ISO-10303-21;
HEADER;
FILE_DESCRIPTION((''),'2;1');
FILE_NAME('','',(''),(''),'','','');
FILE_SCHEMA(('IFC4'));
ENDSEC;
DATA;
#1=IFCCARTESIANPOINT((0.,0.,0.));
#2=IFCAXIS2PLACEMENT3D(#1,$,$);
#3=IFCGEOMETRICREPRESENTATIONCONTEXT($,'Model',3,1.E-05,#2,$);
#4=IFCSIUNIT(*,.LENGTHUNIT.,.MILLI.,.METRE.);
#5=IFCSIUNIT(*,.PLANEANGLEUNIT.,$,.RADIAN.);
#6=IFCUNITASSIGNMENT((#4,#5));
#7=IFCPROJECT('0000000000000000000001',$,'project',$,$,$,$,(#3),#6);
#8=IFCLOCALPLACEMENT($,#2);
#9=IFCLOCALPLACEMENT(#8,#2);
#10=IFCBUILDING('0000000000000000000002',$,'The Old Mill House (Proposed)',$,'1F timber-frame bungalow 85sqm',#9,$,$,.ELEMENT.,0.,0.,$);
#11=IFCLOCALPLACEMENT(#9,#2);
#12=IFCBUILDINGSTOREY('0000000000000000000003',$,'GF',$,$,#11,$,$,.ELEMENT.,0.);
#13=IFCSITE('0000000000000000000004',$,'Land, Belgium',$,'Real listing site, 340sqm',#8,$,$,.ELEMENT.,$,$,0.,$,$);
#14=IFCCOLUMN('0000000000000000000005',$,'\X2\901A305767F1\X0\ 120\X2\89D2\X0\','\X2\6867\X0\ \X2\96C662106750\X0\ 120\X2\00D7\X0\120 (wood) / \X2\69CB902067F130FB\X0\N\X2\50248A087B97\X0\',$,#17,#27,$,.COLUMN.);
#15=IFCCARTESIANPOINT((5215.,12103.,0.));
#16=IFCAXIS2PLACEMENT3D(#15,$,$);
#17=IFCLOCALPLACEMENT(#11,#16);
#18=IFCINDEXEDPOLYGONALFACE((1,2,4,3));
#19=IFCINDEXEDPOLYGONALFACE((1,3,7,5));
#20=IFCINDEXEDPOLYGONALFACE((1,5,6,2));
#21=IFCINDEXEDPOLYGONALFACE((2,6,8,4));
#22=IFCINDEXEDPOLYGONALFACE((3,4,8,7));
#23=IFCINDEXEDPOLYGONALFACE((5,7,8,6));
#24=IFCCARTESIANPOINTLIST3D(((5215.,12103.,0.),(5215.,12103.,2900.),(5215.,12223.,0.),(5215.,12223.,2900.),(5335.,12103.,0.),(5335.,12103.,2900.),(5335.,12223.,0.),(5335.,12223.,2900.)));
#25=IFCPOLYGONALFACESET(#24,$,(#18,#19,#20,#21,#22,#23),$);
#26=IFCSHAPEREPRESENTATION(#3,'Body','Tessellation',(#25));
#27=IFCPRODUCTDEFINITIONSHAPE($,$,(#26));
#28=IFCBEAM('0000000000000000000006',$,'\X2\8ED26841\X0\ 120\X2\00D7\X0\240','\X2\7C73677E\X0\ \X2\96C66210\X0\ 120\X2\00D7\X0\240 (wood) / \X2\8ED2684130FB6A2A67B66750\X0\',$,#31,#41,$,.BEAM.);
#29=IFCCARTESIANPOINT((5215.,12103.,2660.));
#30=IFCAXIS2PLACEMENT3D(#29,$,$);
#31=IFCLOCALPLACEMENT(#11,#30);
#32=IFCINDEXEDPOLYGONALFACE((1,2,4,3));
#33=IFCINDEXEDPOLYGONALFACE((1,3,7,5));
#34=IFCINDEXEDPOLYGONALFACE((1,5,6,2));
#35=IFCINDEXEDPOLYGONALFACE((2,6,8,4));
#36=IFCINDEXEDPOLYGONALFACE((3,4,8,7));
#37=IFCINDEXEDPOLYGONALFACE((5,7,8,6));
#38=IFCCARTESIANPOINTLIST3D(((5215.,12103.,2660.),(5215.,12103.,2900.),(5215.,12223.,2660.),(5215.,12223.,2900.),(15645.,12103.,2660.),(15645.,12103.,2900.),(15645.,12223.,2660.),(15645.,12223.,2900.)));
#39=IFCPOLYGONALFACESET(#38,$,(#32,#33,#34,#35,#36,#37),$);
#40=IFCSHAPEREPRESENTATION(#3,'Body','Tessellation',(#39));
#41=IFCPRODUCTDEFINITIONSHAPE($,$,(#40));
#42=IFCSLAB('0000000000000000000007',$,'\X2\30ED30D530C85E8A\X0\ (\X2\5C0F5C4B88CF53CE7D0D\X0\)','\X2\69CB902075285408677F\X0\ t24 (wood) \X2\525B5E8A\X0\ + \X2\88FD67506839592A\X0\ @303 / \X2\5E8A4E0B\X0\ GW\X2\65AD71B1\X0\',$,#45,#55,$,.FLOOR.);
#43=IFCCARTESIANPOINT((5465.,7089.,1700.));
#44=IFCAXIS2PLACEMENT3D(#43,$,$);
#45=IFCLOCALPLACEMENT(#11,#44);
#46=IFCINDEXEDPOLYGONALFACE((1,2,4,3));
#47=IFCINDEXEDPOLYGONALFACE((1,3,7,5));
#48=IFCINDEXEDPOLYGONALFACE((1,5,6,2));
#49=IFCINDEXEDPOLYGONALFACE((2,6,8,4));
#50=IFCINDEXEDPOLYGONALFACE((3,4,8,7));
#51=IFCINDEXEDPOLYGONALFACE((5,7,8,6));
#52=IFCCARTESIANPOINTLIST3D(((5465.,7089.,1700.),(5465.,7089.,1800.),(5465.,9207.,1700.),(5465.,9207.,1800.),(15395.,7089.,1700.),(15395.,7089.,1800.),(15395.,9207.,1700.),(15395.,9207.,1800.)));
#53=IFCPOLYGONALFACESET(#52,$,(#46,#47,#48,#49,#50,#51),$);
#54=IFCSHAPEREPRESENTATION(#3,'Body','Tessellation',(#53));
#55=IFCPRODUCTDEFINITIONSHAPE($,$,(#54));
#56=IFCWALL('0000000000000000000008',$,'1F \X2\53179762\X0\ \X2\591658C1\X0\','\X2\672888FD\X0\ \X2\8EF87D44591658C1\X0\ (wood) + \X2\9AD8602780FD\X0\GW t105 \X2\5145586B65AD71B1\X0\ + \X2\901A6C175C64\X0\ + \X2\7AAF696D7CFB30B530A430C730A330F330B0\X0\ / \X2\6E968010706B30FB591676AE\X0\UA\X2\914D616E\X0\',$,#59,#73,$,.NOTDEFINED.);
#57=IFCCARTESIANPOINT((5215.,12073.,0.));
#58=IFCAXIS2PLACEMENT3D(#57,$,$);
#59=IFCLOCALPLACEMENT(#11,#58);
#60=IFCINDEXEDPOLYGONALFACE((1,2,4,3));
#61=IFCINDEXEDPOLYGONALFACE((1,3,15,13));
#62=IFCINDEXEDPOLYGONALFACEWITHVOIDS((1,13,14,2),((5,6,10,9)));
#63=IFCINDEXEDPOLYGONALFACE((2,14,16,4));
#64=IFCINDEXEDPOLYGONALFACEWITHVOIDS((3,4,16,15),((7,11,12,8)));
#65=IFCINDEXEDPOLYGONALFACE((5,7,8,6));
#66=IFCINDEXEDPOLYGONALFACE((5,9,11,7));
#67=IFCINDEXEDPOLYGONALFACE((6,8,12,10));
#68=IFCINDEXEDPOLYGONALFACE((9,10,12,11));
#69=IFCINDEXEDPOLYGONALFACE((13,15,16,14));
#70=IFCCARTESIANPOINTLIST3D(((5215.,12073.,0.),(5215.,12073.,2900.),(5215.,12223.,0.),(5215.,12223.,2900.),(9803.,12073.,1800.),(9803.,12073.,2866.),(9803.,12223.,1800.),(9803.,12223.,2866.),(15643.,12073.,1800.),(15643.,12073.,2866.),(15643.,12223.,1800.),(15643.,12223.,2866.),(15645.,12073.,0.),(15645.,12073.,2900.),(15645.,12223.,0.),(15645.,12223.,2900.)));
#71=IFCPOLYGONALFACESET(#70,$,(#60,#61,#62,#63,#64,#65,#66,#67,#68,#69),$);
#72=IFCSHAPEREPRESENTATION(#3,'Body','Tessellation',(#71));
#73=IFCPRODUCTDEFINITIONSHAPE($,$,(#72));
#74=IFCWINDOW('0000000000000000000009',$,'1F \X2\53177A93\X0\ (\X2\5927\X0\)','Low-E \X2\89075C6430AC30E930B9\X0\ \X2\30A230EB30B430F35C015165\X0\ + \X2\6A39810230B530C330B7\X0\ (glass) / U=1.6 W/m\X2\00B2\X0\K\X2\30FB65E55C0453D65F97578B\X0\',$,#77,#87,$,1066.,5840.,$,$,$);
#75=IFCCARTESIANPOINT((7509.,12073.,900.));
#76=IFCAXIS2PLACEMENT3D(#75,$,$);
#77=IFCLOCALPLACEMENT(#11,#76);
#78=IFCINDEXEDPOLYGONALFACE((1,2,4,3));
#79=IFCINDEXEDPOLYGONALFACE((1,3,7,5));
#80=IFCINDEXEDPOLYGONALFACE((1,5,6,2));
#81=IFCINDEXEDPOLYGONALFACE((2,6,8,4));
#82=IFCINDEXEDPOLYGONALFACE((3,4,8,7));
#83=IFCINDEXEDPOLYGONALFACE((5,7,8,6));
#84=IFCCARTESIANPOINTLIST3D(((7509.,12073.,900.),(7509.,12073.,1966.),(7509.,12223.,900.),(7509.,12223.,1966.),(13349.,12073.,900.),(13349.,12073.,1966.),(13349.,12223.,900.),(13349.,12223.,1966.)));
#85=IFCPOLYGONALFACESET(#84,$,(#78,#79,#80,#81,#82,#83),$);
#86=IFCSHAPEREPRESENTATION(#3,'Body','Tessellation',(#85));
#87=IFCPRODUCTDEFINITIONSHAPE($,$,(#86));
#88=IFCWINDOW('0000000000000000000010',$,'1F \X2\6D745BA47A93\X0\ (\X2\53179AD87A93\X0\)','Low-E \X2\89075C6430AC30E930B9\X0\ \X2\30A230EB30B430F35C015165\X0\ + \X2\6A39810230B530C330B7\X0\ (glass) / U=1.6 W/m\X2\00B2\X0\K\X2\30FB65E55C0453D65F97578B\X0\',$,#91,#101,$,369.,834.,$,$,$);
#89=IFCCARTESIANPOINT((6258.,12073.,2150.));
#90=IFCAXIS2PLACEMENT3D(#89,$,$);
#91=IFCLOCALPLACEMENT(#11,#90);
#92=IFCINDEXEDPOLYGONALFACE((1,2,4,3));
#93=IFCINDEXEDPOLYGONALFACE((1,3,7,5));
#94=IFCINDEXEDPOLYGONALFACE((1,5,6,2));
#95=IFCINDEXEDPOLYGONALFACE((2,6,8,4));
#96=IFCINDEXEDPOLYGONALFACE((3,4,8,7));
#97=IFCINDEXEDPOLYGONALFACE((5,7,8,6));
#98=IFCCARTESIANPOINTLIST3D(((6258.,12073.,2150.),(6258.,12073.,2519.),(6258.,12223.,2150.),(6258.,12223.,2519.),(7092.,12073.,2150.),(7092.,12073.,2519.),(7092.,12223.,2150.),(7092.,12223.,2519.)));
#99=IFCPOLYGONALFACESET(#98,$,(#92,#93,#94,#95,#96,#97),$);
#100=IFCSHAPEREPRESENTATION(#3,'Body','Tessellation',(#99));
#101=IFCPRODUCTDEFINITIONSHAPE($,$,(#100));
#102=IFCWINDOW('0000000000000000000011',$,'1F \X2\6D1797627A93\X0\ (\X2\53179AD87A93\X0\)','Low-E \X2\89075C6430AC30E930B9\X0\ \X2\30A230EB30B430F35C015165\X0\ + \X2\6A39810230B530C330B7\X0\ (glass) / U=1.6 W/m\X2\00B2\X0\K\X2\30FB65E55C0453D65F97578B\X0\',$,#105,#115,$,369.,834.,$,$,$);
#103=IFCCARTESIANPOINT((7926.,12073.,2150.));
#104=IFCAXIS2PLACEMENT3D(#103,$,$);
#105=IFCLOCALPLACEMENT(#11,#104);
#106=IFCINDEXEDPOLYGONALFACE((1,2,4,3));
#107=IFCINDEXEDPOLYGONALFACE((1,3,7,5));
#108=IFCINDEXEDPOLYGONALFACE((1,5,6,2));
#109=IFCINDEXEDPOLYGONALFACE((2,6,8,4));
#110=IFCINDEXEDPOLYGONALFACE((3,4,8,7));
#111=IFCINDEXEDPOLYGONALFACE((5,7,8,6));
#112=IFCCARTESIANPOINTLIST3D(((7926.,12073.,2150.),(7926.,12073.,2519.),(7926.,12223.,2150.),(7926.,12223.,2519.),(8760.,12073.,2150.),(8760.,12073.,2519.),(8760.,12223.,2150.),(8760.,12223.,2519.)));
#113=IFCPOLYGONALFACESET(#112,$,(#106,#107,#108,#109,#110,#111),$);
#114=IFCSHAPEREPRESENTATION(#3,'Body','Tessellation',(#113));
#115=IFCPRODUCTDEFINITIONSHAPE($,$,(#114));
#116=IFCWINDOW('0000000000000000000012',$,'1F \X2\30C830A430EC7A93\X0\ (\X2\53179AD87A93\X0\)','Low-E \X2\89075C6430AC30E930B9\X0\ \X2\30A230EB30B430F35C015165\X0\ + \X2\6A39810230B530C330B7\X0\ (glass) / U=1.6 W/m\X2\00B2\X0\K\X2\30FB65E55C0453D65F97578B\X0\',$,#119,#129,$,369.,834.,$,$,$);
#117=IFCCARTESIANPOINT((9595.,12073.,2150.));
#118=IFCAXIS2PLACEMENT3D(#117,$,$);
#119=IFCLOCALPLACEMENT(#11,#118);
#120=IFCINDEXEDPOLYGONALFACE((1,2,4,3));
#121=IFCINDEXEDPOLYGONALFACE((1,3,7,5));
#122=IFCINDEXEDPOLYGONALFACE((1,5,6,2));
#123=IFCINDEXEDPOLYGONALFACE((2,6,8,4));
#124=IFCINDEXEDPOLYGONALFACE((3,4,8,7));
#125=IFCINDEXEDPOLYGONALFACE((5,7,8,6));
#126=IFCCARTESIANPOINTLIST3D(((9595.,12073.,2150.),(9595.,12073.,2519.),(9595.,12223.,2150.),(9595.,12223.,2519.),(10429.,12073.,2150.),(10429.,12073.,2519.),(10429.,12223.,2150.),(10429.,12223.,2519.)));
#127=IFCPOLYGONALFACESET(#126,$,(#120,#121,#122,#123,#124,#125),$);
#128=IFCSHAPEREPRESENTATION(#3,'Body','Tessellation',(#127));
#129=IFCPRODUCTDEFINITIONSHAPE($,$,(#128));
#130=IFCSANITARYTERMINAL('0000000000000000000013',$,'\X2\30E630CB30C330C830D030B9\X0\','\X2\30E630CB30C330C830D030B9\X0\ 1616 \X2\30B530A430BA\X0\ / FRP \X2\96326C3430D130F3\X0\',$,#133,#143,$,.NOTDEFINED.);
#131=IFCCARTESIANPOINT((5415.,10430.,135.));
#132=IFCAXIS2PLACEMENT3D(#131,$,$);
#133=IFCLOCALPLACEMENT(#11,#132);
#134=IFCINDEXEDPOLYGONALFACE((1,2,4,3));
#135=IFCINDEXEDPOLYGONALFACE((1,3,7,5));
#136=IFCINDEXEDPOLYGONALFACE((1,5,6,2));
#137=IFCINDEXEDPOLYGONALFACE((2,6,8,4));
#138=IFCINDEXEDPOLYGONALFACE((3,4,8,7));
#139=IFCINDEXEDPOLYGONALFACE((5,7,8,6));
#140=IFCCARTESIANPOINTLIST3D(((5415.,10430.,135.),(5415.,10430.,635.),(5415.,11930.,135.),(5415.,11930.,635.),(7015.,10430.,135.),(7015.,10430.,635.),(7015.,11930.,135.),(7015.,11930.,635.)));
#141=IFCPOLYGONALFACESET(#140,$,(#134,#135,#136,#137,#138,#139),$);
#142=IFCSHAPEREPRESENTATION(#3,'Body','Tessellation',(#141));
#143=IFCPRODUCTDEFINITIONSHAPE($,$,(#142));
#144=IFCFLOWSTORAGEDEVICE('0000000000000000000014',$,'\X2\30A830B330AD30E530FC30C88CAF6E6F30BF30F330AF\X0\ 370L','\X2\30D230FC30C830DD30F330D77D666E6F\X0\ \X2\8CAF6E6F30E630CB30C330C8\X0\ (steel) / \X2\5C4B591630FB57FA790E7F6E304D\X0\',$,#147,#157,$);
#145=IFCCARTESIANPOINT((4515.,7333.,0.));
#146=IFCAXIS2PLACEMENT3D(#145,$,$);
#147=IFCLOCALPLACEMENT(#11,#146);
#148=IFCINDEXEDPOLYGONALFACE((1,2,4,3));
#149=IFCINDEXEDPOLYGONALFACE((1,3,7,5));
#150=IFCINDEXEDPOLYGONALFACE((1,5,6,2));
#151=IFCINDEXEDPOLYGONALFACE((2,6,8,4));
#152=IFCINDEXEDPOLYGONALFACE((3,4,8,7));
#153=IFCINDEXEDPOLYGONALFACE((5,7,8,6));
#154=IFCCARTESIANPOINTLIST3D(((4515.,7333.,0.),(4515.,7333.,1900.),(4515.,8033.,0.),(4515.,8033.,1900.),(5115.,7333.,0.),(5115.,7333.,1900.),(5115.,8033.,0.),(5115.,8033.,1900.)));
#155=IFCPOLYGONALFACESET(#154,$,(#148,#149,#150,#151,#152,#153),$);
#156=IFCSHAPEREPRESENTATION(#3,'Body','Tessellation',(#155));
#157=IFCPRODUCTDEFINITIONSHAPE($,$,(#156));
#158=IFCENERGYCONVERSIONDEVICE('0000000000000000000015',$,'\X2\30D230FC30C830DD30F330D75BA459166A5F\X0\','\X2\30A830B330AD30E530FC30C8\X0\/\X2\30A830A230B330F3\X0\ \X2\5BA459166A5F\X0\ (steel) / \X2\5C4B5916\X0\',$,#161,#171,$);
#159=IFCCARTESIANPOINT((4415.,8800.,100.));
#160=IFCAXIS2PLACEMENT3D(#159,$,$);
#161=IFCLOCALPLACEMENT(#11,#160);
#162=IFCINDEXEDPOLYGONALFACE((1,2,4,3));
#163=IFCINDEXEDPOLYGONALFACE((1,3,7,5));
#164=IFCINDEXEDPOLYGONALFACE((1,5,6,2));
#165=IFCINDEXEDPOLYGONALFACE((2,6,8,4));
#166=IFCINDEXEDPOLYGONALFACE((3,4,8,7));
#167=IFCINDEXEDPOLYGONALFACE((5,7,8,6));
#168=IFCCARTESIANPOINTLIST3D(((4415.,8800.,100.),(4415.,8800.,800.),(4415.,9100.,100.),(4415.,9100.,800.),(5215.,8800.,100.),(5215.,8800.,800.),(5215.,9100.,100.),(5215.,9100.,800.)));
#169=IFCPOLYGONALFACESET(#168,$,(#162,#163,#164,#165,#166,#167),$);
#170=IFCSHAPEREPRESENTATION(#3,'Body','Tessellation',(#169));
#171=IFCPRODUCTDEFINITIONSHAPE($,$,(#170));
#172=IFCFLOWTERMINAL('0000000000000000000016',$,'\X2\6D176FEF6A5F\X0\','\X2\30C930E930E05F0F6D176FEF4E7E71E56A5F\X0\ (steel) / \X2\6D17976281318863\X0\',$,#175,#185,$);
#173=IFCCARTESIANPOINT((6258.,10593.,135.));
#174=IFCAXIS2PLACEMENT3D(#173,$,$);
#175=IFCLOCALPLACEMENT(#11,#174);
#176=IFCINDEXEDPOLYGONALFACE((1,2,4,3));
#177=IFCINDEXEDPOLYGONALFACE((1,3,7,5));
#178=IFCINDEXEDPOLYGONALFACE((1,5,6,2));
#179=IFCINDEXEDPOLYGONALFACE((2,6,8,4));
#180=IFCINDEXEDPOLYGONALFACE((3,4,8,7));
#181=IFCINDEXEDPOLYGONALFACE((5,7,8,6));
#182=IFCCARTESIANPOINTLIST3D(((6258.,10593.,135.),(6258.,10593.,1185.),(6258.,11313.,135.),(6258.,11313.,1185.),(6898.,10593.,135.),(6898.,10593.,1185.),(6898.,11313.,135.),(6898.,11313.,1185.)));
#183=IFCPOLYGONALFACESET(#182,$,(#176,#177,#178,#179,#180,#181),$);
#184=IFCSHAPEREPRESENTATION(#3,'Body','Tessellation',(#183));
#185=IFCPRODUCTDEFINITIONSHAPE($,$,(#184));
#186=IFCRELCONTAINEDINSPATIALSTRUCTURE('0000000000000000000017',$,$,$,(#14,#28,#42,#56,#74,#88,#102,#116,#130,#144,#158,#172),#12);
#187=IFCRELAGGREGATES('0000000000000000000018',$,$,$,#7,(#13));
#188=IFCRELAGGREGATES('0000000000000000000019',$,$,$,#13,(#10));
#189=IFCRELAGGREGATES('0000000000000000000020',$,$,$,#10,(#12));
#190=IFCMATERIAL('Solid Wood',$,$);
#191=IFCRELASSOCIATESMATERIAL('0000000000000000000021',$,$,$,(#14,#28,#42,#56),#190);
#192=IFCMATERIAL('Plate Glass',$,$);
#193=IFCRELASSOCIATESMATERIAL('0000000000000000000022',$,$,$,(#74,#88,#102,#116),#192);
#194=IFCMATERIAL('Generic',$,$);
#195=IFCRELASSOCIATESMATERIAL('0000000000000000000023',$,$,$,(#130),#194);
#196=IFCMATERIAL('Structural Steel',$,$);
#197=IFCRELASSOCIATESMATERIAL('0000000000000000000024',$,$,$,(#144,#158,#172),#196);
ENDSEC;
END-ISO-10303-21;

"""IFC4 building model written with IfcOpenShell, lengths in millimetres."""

from ifc_helpers import new_model, si_unit, frame, frame_2d, origin, place, context, project, spatial, rectangle, extrude, material, element, fill, save


model = new_model("IFC4")

# Units and contexts
model_context = context("Model", 3, precision=1e-05, world=origin())
ifc_project = project(units=[si_unit("LENGTHUNIT", "METRE", prefix="MILLI"), si_unit("PLANEANGLEUNIT", "RADIAN")], contexts=[model_context])

# Site, building, storey
site_placement = place(None, origin())
site = spatial("IfcSite", under=ifc_project, at=site_placement, Name="Land, Belgium", ObjectType="Real listing site, 340sqm", CompositionType="ELEMENT", RefElevation=0.0)
building_placement = place(site_placement, origin())
building = spatial("IfcBuilding", under=site, at=building_placement, Name="The Old Mill House (Proposed)", ObjectType="1F timber-frame bungalow 85sqm", CompositionType="ELEMENT", ElevationOfRefHeight=0.0, ElevationOfTerrain=0.0)
storey_placement = place(building_placement, origin())
storey = spatial("IfcBuildingStorey", under=building, at=storey_placement, Name="GF", CompositionType="ELEMENT", Elevation=0.0)

# Column
ifc_material_1 = material(Name="Solid Wood")
column_1_placement = place(storey_placement, frame((5215.0, 12103.0, 0.0)))
element("IfcColumn", 1, at=column_1_placement, inside=storey, material=ifc_material_1, Name="通し柱 120角", Description="桧 集成材 120×120 (wood) / 構造柱・N値計算", PredefinedType="COLUMN", context=model_context, shape_type="SweptSolid", body=[
    extrude(rectangle(XDim=120.0, YDim=120.0, at=frame_2d((60.0, 60.0))), frame((5215.0, 12103.0, 0.0)), (0.0, 0.0, 1.0), 2900.0),
])

# Beam
beam_1_placement = place(storey_placement, frame((5215.0, 12103.0, 2660.0)))
element("IfcBeam", 2, at=beam_1_placement, inside=storey, material=ifc_material_1, Name="軒桁 120×240", Description="米松 集成 120×240 (wood) / 軒桁・横架材", PredefinedType="BEAM", context=model_context, shape_type="SweptSolid", body=[
    extrude(rectangle(XDim=10430.0, YDim=120.0, at=frame_2d((5215.0, 60.0))), frame((5215.0, 12103.0, 2660.0)), (0.0, 0.0, 1.0), 240.0),
])

# Slab
slab_placement = place(storey_placement, frame((5465.0, 7089.0, 1700.0)))
element("IfcSlab", 3, at=slab_placement, inside=storey, material=ifc_material_1, Name="ロフト床 (小屋裏収納)", Description="構造用合板 t24 (wood) 剛床 + 製材根太 @303 / 床下 GW断熱", PredefinedType="FLOOR", context=model_context, shape_type="SweptSolid", body=[
    extrude(rectangle(XDim=9930.0, YDim=2118.0, at=frame_2d((4965.0, 1059.0))), frame((5465.0, 7089.0, 1700.0)), (0.0, 0.0, 1.0), 100.0),
])

# Wall, openings, windows
wall_1_placement = place(storey_placement, frame((5215.0, 12073.0, 0.0)))
wall_1 = element("IfcWall", 4, at=wall_1_placement, inside=storey, material=ifc_material_1, Name="1F 北面 外壁", Description="木製 軸組外壁 (wood) + 高性能GW t105 充填断熱 + 通気層 + 窯業系サイディング / 準耐火・外皮UA配慮", PredefinedType="NOTDEFINED", context=model_context, shape_type="SweptSolid", body=[
    extrude(rectangle(XDim=10430.0, YDim=150.0, at=frame_2d((5215.0, 75.0))), frame((5215.0, 12073.0, 0.0)), (0.0, 0.0, 1.0), 2900.0),
])
opening_1_placement = place(storey_placement, frame((7509.0, 12073.0, 900.0)))
opening_1 = element("IfcOpeningElement", 5, at=opening_1_placement, cuts=wall_1, PredefinedType="NOTDEFINED", context=model_context, shape_type="SweptSolid", body=[
    extrude(rectangle(XDim=5840.0, YDim=150.0, at=frame_2d((2920.0, 75.0))), frame((7509.0, 12073.0, 900.0)), (0.0, 0.0, 1.0), 1066.0),
])
opening_2_placement = place(storey_placement, frame((6258.0, 12073.0, 2150.0)))
opening_2 = element("IfcOpeningElement", 6, at=opening_2_placement, cuts=wall_1, PredefinedType="NOTDEFINED", context=model_context, shape_type="SweptSolid", body=[
    extrude(rectangle(XDim=834.0, YDim=150.0, at=frame_2d((417.0, 75.0))), frame((6258.0, 12073.0, 2150.0)), (0.0, 0.0, 1.0), 369.0),
])
opening_3_placement = place(storey_placement, frame((7926.0, 12073.0, 2150.0)))
opening_3 = element("IfcOpeningElement", 7, at=opening_3_placement, cuts=wall_1, PredefinedType="NOTDEFINED", context=model_context, shape_type="SweptSolid", body=[
    extrude(rectangle(XDim=834.0, YDim=150.0, at=frame_2d((417.0, 75.0))), frame((7926.0, 12073.0, 2150.0)), (0.0, 0.0, 1.0), 369.0),
])
opening_4_placement = place(storey_placement, frame((9595.0, 12073.0, 2150.0)))
opening_4 = element("IfcOpeningElement", 8, at=opening_4_placement, cuts=wall_1, PredefinedType="NOTDEFINED", context=model_context, shape_type="SweptSolid", body=[
    extrude(rectangle(XDim=834.0, YDim=150.0, at=frame_2d((417.0, 75.0))), frame((9595.0, 12073.0, 2150.0)), (0.0, 0.0, 1.0), 369.0),
])
ifc_material_2 = material(Name="Plate Glass")
window_1_placement = place(storey_placement, frame((7509.0, 12073.0, 900.0)))
window_1 = element("IfcWindow", 9, at=window_1_placement, inside=storey, material=ifc_material_2, Name="1F 北窓 (大)", Description="Low-E 複層ガラス アルゴン封入 + 樹脂サッシ (glass) / U=1.6 W/m²K・日射取得型", OverallHeight=1066.0, OverallWidth=5840.0, context=model_context, shape_type="SweptSolid", body=[
    extrude(rectangle(XDim=5840.0, YDim=150.0, at=frame_2d((2920.0, 75.0))), frame((7509.0, 12073.0, 900.0)), (0.0, 0.0, 1.0), 1066.0),
])
fill(opening_1, window_1)
window_2_placement = place(storey_placement, frame((6258.0, 12073.0, 2150.0)))
window_2 = element("IfcWindow", 10, at=window_2_placement, inside=storey, material=ifc_material_2, Name="1F 浴室窓 (北高窓)", Description="Low-E 複層ガラス アルゴン封入 + 樹脂サッシ (glass) / U=1.6 W/m²K・日射取得型", OverallHeight=369.0, OverallWidth=834.0, context=model_context, shape_type="SweptSolid", body=[
    extrude(rectangle(XDim=834.0, YDim=150.0, at=frame_2d((417.0, 75.0))), frame((6258.0, 12073.0, 2150.0)), (0.0, 0.0, 1.0), 369.0),
])
fill(opening_2, window_2)
window_3_placement = place(storey_placement, frame((7926.0, 12073.0, 2150.0)))
window_3 = element("IfcWindow", 11, at=window_3_placement, inside=storey, material=ifc_material_2, Name="1F 洗面窓 (北高窓)", Description="Low-E 複層ガラス アルゴン封入 + 樹脂サッシ (glass) / U=1.6 W/m²K・日射取得型", OverallHeight=369.0, OverallWidth=834.0, context=model_context, shape_type="SweptSolid", body=[
    extrude(rectangle(XDim=834.0, YDim=150.0, at=frame_2d((417.0, 75.0))), frame((7926.0, 12073.0, 2150.0)), (0.0, 0.0, 1.0), 369.0),
])
fill(opening_3, window_3)
window_4_placement = place(storey_placement, frame((9595.0, 12073.0, 2150.0)))
window_4 = element("IfcWindow", 12, at=window_4_placement, inside=storey, material=ifc_material_2, Name="1F トイレ窓 (北高窓)", Description="Low-E 複層ガラス アルゴン封入 + 樹脂サッシ (glass) / U=1.6 W/m²K・日射取得型", OverallHeight=369.0, OverallWidth=834.0, context=model_context, shape_type="SweptSolid", body=[
    extrude(rectangle(XDim=834.0, YDim=150.0, at=frame_2d((417.0, 75.0))), frame((9595.0, 12073.0, 2150.0)), (0.0, 0.0, 1.0), 369.0),
])
fill(opening_4, window_4)

# Sanitary terminal
ifc_material_3 = material(Name="Generic")
sanitary_terminal_placement = place(storey_placement, frame((5415.0, 10430.0, 135.0)))
element("IfcSanitaryTerminal", 13, at=sanitary_terminal_placement, inside=storey, material=ifc_material_3, Name="ユニットバス", Description="ユニットバス 1616 サイズ / FRP 防水パン", PredefinedType="NOTDEFINED", context=model_context, shape_type="SweptSolid", body=[
    extrude(rectangle(XDim=1600.0, YDim=1500.0, at=frame_2d((800.0, 750.0))), frame((5415.0, 10430.0, 135.0)), (0.0, 0.0, 1.0), 500.0),
])

# Flow storage device
ifc_material_4 = material(Name="Structural Steel")
flow_storage_device_placement = place(storey_placement, frame((4515.0, 7333.0, 0.0)))
element("IfcFlowStorageDevice", 14, at=flow_storage_device_placement, inside=storey, material=ifc_material_4, Name="エコキュート貯湯タンク 370L", Description="ヒートポンプ給湯 貯湯ユニット (steel) / 屋外・基礎置き", context=model_context, shape_type="SweptSolid", body=[
    extrude(rectangle(XDim=600.0, YDim=700.0, at=frame_2d((300.0, 350.0))), frame((4515.0, 7333.0, 0.0)), (0.0, 0.0, 1.0), 1900.0),
])

# Energy conversion device
energy_conversion_device_placement = place(storey_placement, frame((4415.0, 8800.0, 100.0)))
element("IfcEnergyConversionDevice", 15, at=energy_conversion_device_placement, inside=storey, material=ifc_material_4, Name="ヒートポンプ室外機", Description="エコキュート/エアコン 室外機 (steel) / 屋外", context=model_context, shape_type="SweptSolid", body=[
    extrude(rectangle(XDim=800.0, YDim=300.0, at=frame_2d((400.0, 150.0))), frame((4415.0, 8800.0, 100.0)), (0.0, 0.0, 1.0), 700.0),
])

# Flow terminal
flow_terminal_placement = place(storey_placement, frame((6258.0, 10593.0, 135.0)))
element("IfcFlowTerminal", 16, at=flow_terminal_placement, inside=storey, material=ifc_material_4, Name="洗濯機", Description="ドラム式洗濯乾燥機 (steel) / 洗面脱衣", context=model_context, shape_type="SweptSolid", body=[
    extrude(rectangle(XDim=640.0, YDim=720.0, at=frame_2d((320.0, 360.0))), frame((6258.0, 10593.0, 135.0)), (0.0, 0.0, 1.0), 1050.0),
])

save(model, "model.ifc")
